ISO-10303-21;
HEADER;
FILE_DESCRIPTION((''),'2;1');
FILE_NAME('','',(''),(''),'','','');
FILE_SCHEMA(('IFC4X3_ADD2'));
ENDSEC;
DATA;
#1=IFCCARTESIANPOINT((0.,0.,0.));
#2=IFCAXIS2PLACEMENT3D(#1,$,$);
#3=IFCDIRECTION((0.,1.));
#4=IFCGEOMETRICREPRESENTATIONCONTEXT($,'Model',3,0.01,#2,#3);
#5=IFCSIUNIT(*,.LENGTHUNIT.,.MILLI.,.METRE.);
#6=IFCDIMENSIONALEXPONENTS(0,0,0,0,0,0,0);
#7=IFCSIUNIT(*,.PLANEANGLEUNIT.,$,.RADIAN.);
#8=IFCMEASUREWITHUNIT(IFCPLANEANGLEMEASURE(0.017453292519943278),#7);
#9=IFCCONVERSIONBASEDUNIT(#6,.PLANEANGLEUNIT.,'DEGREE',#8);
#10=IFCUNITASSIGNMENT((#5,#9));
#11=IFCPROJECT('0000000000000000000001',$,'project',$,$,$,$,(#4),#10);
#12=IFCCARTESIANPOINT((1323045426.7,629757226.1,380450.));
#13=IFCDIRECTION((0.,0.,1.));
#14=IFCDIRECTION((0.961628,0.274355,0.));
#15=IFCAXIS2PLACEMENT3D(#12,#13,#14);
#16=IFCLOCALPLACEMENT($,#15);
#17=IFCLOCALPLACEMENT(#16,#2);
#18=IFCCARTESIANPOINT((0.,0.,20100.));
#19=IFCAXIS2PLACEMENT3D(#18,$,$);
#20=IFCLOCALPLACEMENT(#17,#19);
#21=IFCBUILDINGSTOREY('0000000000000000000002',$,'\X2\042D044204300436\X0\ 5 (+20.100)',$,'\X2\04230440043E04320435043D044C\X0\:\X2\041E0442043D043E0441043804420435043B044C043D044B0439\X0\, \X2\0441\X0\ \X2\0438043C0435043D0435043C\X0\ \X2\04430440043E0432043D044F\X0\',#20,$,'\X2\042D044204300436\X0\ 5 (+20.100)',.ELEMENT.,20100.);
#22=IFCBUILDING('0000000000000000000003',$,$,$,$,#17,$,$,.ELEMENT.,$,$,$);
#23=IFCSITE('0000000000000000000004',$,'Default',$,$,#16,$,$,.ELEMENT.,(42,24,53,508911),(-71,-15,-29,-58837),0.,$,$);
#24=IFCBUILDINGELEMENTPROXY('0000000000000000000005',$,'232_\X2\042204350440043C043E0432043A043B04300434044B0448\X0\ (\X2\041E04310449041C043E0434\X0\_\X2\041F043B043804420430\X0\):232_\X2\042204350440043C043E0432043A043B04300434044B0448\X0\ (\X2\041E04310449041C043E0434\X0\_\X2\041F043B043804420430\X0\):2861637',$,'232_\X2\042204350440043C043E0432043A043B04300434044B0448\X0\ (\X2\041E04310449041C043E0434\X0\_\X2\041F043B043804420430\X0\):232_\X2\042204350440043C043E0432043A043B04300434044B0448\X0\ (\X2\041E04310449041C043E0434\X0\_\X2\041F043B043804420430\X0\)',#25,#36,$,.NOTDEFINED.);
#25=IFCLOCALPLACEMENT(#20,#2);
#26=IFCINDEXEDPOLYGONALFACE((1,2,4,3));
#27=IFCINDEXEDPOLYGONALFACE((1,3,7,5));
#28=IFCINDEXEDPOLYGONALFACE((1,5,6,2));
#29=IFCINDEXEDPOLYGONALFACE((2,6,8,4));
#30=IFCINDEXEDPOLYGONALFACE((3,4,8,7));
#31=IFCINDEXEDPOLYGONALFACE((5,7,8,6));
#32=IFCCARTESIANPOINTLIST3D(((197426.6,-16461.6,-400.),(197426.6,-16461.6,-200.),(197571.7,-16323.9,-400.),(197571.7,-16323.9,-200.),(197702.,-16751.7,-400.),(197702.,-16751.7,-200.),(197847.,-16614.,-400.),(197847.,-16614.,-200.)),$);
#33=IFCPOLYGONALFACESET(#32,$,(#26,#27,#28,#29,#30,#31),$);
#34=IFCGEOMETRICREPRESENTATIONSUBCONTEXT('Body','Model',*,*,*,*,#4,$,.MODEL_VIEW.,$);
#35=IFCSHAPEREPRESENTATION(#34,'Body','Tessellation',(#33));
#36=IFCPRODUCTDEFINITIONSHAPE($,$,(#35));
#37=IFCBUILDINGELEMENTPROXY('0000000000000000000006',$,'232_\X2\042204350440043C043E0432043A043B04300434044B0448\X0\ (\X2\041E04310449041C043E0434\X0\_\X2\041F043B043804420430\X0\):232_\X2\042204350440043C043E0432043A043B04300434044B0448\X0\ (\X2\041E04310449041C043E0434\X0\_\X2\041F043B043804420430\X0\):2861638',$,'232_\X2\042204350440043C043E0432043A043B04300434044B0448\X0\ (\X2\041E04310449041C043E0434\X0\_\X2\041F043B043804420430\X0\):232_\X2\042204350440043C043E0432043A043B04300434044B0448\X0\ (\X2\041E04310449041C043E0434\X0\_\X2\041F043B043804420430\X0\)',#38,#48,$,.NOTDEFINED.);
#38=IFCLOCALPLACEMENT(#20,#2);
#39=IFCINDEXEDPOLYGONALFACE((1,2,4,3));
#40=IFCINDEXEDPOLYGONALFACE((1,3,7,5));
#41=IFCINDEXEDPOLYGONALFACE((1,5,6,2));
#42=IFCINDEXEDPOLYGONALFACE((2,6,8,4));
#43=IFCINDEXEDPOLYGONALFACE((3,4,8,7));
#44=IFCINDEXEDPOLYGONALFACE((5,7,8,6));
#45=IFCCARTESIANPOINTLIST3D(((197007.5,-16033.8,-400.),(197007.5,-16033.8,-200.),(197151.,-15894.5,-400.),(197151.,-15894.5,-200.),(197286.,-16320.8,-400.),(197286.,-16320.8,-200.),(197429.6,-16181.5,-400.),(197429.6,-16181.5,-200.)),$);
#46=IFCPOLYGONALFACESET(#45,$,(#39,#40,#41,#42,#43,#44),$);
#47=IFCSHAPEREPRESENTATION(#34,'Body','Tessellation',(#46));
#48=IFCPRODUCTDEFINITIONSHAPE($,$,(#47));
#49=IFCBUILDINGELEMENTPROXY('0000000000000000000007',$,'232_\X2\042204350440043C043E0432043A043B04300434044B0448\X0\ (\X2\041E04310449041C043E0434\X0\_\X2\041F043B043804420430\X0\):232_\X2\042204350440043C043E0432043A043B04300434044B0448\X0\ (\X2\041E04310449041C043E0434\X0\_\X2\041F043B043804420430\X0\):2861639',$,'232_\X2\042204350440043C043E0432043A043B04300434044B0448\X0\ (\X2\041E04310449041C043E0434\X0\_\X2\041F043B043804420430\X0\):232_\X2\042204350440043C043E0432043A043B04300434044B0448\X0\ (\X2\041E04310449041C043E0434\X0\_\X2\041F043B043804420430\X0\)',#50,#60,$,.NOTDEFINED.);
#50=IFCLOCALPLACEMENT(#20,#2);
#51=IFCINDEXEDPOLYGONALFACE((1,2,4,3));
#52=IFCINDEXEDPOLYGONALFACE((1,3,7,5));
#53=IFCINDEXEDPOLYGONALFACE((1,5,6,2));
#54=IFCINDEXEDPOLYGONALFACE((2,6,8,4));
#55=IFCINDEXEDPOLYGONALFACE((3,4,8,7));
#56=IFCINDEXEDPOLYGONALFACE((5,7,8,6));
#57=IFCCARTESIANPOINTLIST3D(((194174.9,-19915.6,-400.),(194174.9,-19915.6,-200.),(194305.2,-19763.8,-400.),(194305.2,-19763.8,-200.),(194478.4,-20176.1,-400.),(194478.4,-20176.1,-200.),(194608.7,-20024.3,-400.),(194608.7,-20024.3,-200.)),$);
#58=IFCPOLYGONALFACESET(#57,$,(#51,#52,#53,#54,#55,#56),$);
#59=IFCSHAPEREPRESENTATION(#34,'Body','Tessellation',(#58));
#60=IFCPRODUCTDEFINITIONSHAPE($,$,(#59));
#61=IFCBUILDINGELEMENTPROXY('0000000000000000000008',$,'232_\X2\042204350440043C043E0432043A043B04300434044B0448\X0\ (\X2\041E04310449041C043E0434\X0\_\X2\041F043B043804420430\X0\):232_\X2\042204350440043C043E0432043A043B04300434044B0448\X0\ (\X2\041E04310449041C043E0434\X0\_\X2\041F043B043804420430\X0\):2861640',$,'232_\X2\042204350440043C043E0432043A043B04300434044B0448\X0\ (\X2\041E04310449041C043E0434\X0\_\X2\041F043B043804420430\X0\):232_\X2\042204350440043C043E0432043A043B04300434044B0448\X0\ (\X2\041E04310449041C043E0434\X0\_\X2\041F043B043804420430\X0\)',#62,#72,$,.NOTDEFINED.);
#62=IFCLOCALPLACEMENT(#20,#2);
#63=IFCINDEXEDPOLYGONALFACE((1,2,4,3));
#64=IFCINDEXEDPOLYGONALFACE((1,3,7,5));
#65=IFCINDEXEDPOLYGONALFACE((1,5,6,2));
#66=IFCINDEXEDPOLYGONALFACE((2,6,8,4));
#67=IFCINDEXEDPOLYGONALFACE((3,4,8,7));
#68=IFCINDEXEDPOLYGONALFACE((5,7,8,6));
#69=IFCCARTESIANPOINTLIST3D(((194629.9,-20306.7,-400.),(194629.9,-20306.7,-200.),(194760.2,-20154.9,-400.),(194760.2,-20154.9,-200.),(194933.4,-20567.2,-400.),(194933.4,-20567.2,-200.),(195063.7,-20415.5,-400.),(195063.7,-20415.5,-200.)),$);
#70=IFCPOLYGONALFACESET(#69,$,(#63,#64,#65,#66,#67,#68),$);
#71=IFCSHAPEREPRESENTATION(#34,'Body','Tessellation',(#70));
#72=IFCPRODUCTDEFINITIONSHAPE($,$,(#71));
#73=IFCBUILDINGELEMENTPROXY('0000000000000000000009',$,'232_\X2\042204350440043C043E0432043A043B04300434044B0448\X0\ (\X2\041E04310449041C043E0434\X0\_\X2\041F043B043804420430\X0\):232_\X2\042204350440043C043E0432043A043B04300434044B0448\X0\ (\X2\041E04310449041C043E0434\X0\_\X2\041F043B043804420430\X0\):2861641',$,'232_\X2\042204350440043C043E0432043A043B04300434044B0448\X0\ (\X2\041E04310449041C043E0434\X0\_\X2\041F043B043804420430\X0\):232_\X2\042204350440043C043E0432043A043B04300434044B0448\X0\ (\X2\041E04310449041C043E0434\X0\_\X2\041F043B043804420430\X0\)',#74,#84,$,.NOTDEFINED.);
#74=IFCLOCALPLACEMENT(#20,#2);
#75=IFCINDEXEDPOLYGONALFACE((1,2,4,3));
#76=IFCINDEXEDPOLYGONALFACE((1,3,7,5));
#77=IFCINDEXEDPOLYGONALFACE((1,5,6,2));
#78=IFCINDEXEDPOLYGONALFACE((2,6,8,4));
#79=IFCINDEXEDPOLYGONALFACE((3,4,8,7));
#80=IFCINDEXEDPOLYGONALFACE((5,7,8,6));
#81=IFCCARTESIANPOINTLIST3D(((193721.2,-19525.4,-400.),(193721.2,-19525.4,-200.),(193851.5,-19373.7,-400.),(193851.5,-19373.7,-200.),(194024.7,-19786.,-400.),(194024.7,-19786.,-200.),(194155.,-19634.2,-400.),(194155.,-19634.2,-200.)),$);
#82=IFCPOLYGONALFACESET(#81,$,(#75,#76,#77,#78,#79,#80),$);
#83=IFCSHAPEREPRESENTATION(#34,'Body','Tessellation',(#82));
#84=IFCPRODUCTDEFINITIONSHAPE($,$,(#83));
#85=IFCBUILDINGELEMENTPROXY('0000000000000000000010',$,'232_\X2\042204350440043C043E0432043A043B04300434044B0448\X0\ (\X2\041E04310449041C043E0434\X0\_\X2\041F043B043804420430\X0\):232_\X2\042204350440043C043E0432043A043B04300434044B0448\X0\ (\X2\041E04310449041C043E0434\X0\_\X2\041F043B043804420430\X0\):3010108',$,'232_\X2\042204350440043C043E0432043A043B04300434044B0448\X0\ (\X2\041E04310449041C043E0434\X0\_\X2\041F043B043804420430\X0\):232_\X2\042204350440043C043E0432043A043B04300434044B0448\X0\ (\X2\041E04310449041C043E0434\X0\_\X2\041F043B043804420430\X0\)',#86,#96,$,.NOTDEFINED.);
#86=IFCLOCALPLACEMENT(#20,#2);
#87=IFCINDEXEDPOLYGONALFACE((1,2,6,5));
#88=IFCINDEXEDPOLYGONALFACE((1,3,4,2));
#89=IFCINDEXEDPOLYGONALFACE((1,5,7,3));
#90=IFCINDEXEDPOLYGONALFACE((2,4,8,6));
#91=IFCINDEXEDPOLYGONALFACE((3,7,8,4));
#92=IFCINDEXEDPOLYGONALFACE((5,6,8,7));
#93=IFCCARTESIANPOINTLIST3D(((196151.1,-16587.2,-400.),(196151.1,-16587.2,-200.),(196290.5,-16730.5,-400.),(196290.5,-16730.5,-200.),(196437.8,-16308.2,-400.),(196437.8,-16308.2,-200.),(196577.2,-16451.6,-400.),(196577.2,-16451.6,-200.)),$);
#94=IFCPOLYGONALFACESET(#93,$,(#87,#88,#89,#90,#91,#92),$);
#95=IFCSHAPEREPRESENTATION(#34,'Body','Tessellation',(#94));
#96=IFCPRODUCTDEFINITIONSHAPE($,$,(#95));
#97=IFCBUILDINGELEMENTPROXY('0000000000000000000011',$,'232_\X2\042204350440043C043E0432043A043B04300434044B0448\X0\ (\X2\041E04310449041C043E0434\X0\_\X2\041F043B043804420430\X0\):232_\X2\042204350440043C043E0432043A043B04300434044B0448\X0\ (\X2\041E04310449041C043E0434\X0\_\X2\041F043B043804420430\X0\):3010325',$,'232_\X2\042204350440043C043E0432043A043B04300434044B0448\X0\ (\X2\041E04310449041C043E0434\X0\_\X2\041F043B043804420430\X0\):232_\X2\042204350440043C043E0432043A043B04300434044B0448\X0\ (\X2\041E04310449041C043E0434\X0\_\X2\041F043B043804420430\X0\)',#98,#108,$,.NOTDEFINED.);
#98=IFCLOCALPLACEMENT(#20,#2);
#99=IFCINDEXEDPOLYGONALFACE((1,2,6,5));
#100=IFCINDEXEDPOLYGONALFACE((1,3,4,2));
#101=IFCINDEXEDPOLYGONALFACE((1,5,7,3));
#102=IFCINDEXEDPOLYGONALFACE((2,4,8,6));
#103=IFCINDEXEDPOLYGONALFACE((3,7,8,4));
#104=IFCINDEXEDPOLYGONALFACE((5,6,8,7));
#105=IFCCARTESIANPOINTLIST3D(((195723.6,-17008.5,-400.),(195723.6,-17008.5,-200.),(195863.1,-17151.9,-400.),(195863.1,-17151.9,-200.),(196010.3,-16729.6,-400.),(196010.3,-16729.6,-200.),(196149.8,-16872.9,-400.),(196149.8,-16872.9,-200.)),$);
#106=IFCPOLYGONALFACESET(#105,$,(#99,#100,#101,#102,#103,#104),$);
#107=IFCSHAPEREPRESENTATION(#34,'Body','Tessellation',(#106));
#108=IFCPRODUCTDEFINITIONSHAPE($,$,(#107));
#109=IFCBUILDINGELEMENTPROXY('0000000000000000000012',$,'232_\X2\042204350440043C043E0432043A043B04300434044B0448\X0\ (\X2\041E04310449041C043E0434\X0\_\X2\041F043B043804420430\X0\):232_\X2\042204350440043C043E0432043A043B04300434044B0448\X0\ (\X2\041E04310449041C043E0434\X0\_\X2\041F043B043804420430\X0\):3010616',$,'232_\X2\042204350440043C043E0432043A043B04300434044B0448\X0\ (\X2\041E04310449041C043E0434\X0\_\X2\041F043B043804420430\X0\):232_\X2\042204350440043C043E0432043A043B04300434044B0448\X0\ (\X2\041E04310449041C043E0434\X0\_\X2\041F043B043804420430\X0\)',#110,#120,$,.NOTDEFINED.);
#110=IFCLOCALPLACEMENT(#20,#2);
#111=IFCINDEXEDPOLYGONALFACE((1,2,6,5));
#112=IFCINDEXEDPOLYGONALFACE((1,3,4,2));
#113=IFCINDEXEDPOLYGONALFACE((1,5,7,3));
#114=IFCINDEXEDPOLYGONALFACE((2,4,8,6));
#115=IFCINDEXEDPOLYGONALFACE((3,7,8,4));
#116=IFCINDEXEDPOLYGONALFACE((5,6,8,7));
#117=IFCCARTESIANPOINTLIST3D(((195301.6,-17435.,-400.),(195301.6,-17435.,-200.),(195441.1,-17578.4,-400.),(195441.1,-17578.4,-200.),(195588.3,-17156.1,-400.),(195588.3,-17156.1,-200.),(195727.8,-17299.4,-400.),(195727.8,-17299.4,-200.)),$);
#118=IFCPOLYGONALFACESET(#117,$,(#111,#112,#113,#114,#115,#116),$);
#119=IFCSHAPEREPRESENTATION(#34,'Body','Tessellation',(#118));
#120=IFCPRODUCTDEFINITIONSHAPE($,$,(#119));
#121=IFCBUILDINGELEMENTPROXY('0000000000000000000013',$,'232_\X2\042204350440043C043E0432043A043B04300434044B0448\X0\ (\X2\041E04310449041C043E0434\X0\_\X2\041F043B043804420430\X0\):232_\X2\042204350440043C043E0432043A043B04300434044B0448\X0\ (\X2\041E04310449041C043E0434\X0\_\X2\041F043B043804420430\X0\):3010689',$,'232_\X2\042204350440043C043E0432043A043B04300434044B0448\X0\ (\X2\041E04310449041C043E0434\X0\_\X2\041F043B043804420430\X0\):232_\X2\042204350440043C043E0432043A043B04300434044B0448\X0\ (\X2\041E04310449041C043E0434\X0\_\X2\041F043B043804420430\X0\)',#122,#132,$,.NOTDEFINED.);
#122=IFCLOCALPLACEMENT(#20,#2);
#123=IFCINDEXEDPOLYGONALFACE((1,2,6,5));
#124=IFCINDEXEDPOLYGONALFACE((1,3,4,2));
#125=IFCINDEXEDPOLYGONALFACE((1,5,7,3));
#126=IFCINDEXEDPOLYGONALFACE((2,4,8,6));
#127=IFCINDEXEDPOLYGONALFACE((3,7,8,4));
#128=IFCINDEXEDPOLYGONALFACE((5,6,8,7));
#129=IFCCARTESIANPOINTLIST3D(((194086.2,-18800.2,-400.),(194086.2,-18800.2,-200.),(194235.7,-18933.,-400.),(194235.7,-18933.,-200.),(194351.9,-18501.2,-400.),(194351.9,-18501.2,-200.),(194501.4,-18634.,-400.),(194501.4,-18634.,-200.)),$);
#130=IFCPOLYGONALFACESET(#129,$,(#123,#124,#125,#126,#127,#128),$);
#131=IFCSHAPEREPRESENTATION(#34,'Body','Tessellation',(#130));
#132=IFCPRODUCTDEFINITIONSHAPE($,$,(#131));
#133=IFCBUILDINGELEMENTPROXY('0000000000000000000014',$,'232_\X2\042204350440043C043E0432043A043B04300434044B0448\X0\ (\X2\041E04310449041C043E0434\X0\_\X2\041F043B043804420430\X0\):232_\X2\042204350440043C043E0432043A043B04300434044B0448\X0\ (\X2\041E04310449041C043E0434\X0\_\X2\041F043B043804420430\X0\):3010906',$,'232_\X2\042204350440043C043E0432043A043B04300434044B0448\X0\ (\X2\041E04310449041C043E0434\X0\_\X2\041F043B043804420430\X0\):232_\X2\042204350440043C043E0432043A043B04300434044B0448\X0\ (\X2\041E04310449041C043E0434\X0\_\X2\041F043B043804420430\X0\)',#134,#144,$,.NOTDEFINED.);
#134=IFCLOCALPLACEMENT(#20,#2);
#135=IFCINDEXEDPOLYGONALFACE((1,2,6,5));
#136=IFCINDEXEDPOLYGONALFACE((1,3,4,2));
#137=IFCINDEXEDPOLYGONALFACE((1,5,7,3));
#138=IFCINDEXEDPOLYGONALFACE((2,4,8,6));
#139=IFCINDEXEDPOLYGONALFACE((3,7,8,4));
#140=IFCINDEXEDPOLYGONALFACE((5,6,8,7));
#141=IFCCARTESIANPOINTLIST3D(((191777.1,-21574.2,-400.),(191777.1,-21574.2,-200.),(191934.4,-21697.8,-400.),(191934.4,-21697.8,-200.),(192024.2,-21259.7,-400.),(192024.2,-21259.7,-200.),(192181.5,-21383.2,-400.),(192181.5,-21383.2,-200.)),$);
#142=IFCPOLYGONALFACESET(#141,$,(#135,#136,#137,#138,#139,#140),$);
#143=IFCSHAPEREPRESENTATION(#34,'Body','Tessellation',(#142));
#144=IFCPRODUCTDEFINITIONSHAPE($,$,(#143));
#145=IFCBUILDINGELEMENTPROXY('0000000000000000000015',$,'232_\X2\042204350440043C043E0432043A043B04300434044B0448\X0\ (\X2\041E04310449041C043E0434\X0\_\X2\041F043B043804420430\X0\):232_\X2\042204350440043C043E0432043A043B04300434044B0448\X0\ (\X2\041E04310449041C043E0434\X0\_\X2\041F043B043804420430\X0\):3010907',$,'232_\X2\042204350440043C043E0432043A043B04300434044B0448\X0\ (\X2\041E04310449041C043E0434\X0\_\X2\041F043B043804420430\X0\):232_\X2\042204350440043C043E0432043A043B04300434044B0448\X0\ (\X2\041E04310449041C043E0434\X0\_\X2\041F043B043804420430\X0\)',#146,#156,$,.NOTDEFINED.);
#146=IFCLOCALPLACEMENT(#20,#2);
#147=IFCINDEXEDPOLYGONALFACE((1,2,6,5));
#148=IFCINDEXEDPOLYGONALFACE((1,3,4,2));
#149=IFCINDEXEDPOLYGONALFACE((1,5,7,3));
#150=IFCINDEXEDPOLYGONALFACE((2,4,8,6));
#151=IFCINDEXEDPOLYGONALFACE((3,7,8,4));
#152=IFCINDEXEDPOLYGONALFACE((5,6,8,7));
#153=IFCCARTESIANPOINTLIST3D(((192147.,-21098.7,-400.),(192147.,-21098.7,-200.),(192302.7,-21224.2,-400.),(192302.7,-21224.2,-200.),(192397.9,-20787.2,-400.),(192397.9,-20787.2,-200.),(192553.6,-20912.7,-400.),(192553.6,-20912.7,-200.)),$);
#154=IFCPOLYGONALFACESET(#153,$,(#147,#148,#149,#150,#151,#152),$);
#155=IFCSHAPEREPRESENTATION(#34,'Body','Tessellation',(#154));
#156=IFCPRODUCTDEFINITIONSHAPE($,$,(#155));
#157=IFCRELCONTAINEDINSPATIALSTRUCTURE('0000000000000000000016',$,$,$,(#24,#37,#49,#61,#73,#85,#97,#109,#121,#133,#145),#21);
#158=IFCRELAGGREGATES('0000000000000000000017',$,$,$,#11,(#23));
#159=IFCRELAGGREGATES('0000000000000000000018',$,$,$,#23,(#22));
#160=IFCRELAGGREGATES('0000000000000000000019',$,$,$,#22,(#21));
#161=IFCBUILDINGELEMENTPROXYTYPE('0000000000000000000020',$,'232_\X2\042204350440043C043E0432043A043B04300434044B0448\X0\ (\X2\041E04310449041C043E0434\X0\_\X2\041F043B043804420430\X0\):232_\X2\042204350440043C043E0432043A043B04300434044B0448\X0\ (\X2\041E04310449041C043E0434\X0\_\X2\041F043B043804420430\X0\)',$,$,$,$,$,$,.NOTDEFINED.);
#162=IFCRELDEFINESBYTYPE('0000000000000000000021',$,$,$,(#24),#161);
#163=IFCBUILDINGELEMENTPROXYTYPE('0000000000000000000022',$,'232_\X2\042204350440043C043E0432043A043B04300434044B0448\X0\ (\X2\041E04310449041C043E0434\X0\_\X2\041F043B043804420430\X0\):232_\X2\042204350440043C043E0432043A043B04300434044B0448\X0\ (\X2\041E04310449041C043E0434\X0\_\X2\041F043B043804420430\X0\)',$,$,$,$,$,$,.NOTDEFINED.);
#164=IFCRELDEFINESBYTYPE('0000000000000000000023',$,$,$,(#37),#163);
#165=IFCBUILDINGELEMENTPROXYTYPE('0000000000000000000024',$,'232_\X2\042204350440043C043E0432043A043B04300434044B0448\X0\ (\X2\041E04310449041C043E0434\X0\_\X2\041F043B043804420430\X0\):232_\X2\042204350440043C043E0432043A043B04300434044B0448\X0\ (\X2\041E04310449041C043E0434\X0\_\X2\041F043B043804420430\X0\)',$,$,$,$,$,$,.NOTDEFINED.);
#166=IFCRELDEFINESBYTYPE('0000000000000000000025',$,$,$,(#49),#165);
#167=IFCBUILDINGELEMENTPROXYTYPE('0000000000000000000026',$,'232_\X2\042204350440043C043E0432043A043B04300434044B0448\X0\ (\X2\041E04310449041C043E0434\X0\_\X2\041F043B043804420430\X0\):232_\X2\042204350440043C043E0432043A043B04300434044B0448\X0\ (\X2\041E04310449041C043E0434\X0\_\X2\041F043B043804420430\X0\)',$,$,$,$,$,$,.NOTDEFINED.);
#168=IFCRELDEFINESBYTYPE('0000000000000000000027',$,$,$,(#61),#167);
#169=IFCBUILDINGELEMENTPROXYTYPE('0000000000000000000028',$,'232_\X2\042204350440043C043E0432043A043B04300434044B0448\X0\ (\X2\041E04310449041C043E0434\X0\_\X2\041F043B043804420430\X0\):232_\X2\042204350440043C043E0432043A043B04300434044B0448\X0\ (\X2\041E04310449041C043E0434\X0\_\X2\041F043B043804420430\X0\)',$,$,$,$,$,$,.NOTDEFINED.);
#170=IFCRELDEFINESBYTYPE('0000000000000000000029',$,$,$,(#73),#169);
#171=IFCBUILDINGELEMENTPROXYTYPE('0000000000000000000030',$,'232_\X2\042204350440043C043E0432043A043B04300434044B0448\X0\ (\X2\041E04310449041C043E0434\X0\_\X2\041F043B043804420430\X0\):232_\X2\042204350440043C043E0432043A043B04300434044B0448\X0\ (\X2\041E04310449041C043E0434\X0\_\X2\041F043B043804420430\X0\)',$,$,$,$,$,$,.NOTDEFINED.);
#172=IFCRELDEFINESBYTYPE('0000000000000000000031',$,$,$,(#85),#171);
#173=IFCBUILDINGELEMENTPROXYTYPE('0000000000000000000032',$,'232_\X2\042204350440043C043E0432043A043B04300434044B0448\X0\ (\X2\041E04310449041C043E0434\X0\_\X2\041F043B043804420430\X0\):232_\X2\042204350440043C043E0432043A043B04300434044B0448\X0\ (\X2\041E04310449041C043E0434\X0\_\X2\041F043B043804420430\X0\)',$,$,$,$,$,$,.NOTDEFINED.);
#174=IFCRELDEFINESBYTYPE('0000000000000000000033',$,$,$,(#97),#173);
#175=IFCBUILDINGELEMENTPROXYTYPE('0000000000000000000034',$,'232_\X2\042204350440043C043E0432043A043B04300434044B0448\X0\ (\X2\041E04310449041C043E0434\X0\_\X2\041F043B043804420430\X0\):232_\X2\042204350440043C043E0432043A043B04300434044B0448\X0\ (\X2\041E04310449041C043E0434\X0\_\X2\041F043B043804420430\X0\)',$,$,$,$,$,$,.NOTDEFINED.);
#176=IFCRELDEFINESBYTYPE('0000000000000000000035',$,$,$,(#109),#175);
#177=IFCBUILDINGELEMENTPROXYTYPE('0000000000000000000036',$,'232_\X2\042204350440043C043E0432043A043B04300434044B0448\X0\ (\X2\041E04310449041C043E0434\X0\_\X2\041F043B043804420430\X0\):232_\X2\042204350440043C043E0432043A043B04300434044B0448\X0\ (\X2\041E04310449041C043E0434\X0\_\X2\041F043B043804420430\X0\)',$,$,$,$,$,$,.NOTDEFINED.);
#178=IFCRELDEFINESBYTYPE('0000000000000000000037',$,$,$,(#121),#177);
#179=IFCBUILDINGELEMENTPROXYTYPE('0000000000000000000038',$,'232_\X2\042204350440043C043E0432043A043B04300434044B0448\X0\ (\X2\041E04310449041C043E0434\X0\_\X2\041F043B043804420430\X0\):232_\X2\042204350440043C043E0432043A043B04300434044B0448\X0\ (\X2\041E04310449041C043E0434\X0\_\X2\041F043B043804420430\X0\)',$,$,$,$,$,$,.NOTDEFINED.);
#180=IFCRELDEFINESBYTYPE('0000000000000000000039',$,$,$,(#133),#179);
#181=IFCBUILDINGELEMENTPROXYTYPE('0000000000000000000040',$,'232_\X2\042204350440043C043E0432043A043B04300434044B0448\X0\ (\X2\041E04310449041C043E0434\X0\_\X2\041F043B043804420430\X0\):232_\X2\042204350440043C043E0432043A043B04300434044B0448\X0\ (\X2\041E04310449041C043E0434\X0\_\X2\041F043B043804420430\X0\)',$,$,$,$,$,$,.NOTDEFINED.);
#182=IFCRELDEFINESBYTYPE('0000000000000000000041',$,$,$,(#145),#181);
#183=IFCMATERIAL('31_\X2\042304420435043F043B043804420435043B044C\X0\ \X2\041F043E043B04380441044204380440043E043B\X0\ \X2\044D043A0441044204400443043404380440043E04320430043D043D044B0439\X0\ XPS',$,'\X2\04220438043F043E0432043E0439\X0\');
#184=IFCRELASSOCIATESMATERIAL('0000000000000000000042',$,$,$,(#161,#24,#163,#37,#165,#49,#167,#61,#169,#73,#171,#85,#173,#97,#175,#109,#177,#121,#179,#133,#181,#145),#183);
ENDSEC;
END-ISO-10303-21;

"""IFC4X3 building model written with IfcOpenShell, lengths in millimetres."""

from ifc_helpers import new_model, entity, si_unit, converted_unit, direction, frame, frame_2d, origin, origin_2d_with_axis, place, context, subcontext, project, spatial, rectangle, extrude, source, transform, mapped, material, type_object, type_shapes, element, save


model = new_model("IFC4X3")

# Units and contexts
model_context = context("Model", 3, precision=0.01, world=origin(), true_north=direction((0.0, 1.0)))
body_context = subcontext(model_context, "Body", "Model", "MODEL_VIEW")
ifc_project = project(units=[si_unit("LENGTHUNIT", "METRE", prefix="MILLI"), converted_unit("PLANEANGLEUNIT", "DEGREE", entity("IfcPlaneAngleMeasure", 0.017453292519943278), si_unit("PLANEANGLEUNIT", "RADIAN"), dimensions=[0, 0, 0, 0, 0, 0, 0])], contexts=[model_context])

# Site, building, storey
site_placement = place(None, frame((1323045426.7, 629757226.1, 380450.0), z_axis=(0.0, 0.0, 1.0), x_axis=(0.961628, 0.274355, 0.0)))
site = spatial("IfcSite", under=ifc_project, at=site_placement, Name="Default", CompositionType="ELEMENT", RefLatitude=(42, 24, 53, 508911), RefLongitude=(-71, -15, -29, -58837), RefElevation=0.0)
building_placement = place(site_placement, origin())
building = spatial("IfcBuilding", under=site, at=building_placement, CompositionType="ELEMENT")
storey_placement = place(building_placement, frame((0.0, 0.0, 20100.0)))
storey = spatial("IfcBuildingStorey", under=building, at=storey_placement, Name="Этаж 5 (+20.100)", ObjectType="Уровень:Относительный, с именем уровня", LongName="Этаж 5 (+20.100)", CompositionType="ELEMENT", Elevation=20100.0)

# Building element proxies
ifc_material_1 = material(Name="31_Утеплитель Полистирол экструдированный XPS", Category="Типовой")
building_element_proxy_type_1 = type_object("IfcBuildingElementProxyType", Name="232_Термовкладыш (ОбщМод_Плита):232_Термовкладыш (ОбщМод_Плита)", PredefinedType="NOTDEFINED", material=ifc_material_1)
shared_shape_1 = source(origin(), body_context, "Body", "SweptSolid", [
    extrude(rectangle(XDim=400.0, YDim=200.0, at=frame_2d((0.0, 0.0), x_axis=(1.0, 0.0))), frame((197636.8, -16537.8, -200.0), z_axis=(0.0, 0.0, 1.0), x_axis=(-0.688483, 0.725252, 0.0)), (0.0, 0.0, 1.0), 200.0),
])
type_shapes(building_element_proxy_type_1, [shared_shape_1])
proxy_1_placement = place(storey_placement, frame((0.0, 0.0, -200.0)))
element("IfcBuildingElementProxy", 1, at=proxy_1_placement, inside=storey, type_object=building_element_proxy_type_1, material=ifc_material_1, Name="232_Термовкладыш (ОбщМод_Плита):232_Термовкладыш (ОбщМод_Плита):2861637", ObjectType="232_Термовкладыш (ОбщМод_Плита):232_Термовкладыш (ОбщМод_Плита)", PredefinedType="NOTDEFINED", context=body_context, shape_type="MappedRepresentation", body=[
    mapped(shared_shape_1, transform((0.0, 0.0, 0.0), scale=1.0)),
])
building_element_proxy_type_2 = type_object("IfcBuildingElementProxyType", Name="232_Термовкладыш (ОбщМод_Плита):232_Термовкладыш (ОбщМод_Плита)", PredefinedType="NOTDEFINED", material=ifc_material_1)
shared_shape_2 = source(origin(), body_context, "Body", "SweptSolid", [
    extrude(rectangle(XDim=400.0, YDim=200.0, at=frame_2d((0.0, 0.0), x_axis=(1.0, 0.0))), frame((197218.5, -16107.6, -200.0), z_axis=(0.0, 0.0, 1.0), x_axis=(-0.696452, 0.717604, 0.0)), (0.0, 0.0, 1.0), 200.0),
])
type_shapes(building_element_proxy_type_2, [shared_shape_2])
proxy_2_placement = place(storey_placement, frame((0.0, 0.0, -200.0)))
element("IfcBuildingElementProxy", 2, at=proxy_2_placement, inside=storey, type_object=building_element_proxy_type_2, material=ifc_material_1, Name="232_Термовкладыш (ОбщМод_Плита):232_Термовкладыш (ОбщМод_Плита):2861638", ObjectType="232_Термовкладыш (ОбщМод_Плита):232_Термовкладыш (ОбщМод_Плита)", PredefinedType="NOTDEFINED", context=body_context, shape_type="MappedRepresentation", body=[
    mapped(shared_shape_2, transform((0.0, 0.0, 0.0), scale=1.0)),
])
building_element_proxy_type_3 = type_object("IfcBuildingElementProxyType", Name="232_Термовкладыш (ОбщМод_Плита):232_Термовкладыш (ОбщМод_Плита)", PredefinedType="NOTDEFINED", material=ifc_material_1)
shared_shape_3 = source(origin(), body_context, "Body", "SweptSolid", [
    extrude(rectangle(XDim=400.0, YDim=200.0, at=frame_2d((0.0, 0.0), x_axis=(1.0, 0.0))), frame((194391.8, -19969.9, -200.0), z_axis=(0.0, 0.0, 1.0), x_axis=(-0.758819, 0.651302, 0.0)), (0.0, 0.0, 1.0), 200.0),
])
type_shapes(building_element_proxy_type_3, [shared_shape_3])
proxy_3_placement = place(storey_placement, frame((0.0, 0.0, -200.0)))
element("IfcBuildingElementProxy", 3, at=proxy_3_placement, inside=storey, type_object=building_element_proxy_type_3, material=ifc_material_1, Name="232_Термовкладыш (ОбщМод_Плита):232_Термовкладыш (ОбщМод_Плита):2861639", ObjectType="232_Термовкладыш (ОбщМод_Плита):232_Термовкладыш (ОбщМод_Плита)", PredefinedType="NOTDEFINED", context=body_context, shape_type="MappedRepresentation", body=[
    mapped(shared_shape_3, transform((0.0, 0.0, 0.0), scale=1.0)),
])
building_element_proxy_type_4 = type_object("IfcBuildingElementProxyType", Name="232_Термовкладыш (ОбщМод_Плита):232_Термовкладыш (ОбщМод_Плита)", PredefinedType="NOTDEFINED", material=ifc_material_1)
shared_shape_4 = source(origin(), body_context, "Body", "SweptSolid", [
    extrude(rectangle(XDim=400.0, YDim=200.0, at=frame_2d((0.0, 0.0), x_axis=(1.0, 0.0))), frame((194846.8, -20361.1, -200.0), z_axis=(0.0, 0.0, 1.0), x_axis=(-0.758819, 0.651302, 0.0)), (0.0, 0.0, 1.0), 200.0),
])
type_shapes(building_element_proxy_type_4, [shared_shape_4])
proxy_4_placement = place(storey_placement, frame((0.0, 0.0, -200.0)))
element("IfcBuildingElementProxy", 4, at=proxy_4_placement, inside=storey, type_object=building_element_proxy_type_4, material=ifc_material_1, Name="232_Термовкладыш (ОбщМод_Плита):232_Термовкладыш (ОбщМод_Плита):2861640", ObjectType="232_Термовкладыш (ОбщМод_Плита):232_Термовкладыш (ОбщМод_Плита)", PredefinedType="NOTDEFINED", context=body_context, shape_type="MappedRepresentation", body=[
    mapped(shared_shape_4, transform((0.0, 0.0, 0.0), scale=1.0)),
])
building_element_proxy_type_5 = type_object("IfcBuildingElementProxyType", Name="232_Термовкладыш (ОбщМод_Плита):232_Термовкладыш (ОбщМод_Плита)", PredefinedType="NOTDEFINED", material=ifc_material_1)
shared_shape_5 = source(origin(), body_context, "Body", "SweptSolid", [
    extrude(rectangle(XDim=400.0, YDim=200.0, at=frame_2d((0.0, 0.0), x_axis=(1.0, 0.0))), frame((193938.1, -19579.8, -200.0), z_axis=(0.0, 0.0, 1.0), x_axis=(-0.758819, 0.651302, 0.0)), (0.0, 0.0, 1.0), 200.0),
])
type_shapes(building_element_proxy_type_5, [shared_shape_5])
proxy_5_placement = place(storey_placement, frame((0.0, 0.0, -200.0)))
element("IfcBuildingElementProxy", 5, at=proxy_5_placement, inside=storey, type_object=building_element_proxy_type_5, material=ifc_material_1, Name="232_Термовкладыш (ОбщМод_Плита):232_Термовкладыш (ОбщМод_Плита):2861641", ObjectType="232_Термовкладыш (ОбщМод_Плита):232_Термовкладыш (ОбщМод_Плита)", PredefinedType="NOTDEFINED", context=body_context, shape_type="MappedRepresentation", body=[
    mapped(shared_shape_5, transform((0.0, 0.0, 0.0), scale=1.0)),
])
building_element_proxy_type_6 = type_object("IfcBuildingElementProxyType", Name="232_Термовкладыш (ОбщМод_Плита):232_Термовкладыш (ОбщМод_Плита)", PredefinedType="NOTDEFINED", material=ifc_material_1)
shared_shape_6 = source(origin(), body_context, "Body", "SweptSolid", [
    extrude(rectangle(XDim=400.0, YDim=200.0, at=frame_2d((0.0, 0.0), x_axis=(1.0, 0.0))), frame((196364.1, -16519.4, -200.0), z_axis=(0.0, 0.0, 1.0), x_axis=(0.716712, 0.697369, 0.0)), (0.0, 0.0, 1.0), 200.0),
])
type_shapes(building_element_proxy_type_6, [shared_shape_6])
proxy_6_placement = place(storey_placement, frame((0.0, 0.0, -200.0)))
element("IfcBuildingElementProxy", 6, at=proxy_6_placement, inside=storey, type_object=building_element_proxy_type_6, material=ifc_material_1, Name="232_Термовкладыш (ОбщМод_Плита):232_Термовкладыш (ОбщМод_Плита):3010108", ObjectType="232_Термовкладыш (ОбщМод_Плита):232_Термовкладыш (ОбщМод_Плита)", PredefinedType="NOTDEFINED", context=body_context, shape_type="MappedRepresentation", body=[
    mapped(shared_shape_6, transform((0.0, 0.0, 0.0), scale=1.0)),
])
building_element_proxy_type_7 = type_object("IfcBuildingElementProxyType", Name="232_Термовкладыш (ОбщМод_Плита):232_Термовкладыш (ОбщМод_Плита)", PredefinedType="NOTDEFINED", material=ifc_material_1)
shared_shape_7 = source(origin(), body_context, "Body", "SweptSolid", [
    extrude(rectangle(XDim=400.0, YDim=200.0, at=frame_2d((0.0, 0.0), x_axis=(1.0, 0.0))), frame((195936.7, -16940.7, -200.0), z_axis=(0.0, 0.0, 1.0), x_axis=(0.716712, 0.697369, 0.0)), (0.0, 0.0, 1.0), 200.0),
])
type_shapes(building_element_proxy_type_7, [shared_shape_7])
proxy_7_placement = place(storey_placement, frame((0.0, 0.0, -200.0)))
element("IfcBuildingElementProxy", 7, at=proxy_7_placement, inside=storey, type_object=building_element_proxy_type_7, material=ifc_material_1, Name="232_Термовкладыш (ОбщМод_Плита):232_Термовкладыш (ОбщМод_Плита):3010325", ObjectType="232_Термовкладыш (ОбщМод_Плита):232_Термовкладыш (ОбщМод_Плита)", PredefinedType="NOTDEFINED", context=body_context, shape_type="MappedRepresentation", body=[
    mapped(shared_shape_7, transform((0.0, 0.0, 0.0), scale=1.0)),
])
building_element_proxy_type_8 = type_object("IfcBuildingElementProxyType", Name="232_Термовкладыш (ОбщМод_Плита):232_Термовкладыш (ОбщМод_Плита)", PredefinedType="NOTDEFINED", material=ifc_material_1)
shared_shape_8 = source(origin(), body_context, "Body", "SweptSolid", [
    extrude(rectangle(XDim=400.0, YDim=200.0, at=frame_2d((0.0, 0.0), x_axis=(1.0, 0.0))), frame((195514.7, -17367.2, -200.0), z_axis=(0.0, 0.0, 1.0), x_axis=(0.716712, 0.697369, 0.0)), (0.0, 0.0, 1.0), 200.0),
])
type_shapes(building_element_proxy_type_8, [shared_shape_8])
proxy_8_placement = place(storey_placement, frame((0.0, 0.0, -200.0)))
element("IfcBuildingElementProxy", 8, at=proxy_8_placement, inside=storey, type_object=building_element_proxy_type_8, material=ifc_material_1, Name="232_Термовкладыш (ОбщМод_Плита):232_Термовкладыш (ОбщМод_Плита):3010616", ObjectType="232_Термовкладыш (ОбщМод_Плита):232_Термовкладыш (ОбщМод_Плита)", PredefinedType="NOTDEFINED", context=body_context, shape_type="MappedRepresentation", body=[
    mapped(shared_shape_8, transform((0.0, 0.0, 0.0), scale=1.0)),
])
building_element_proxy_type_9 = type_object("IfcBuildingElementProxyType", Name="232_Термовкладыш (ОбщМод_Плита):232_Термовкладыш (ОбщМод_Плита)", PredefinedType="NOTDEFINED", material=ifc_material_1)
shared_shape_9 = source(origin(), body_context, "Body", "SweptSolid", [
    extrude(rectangle(XDim=400.0, YDim=200.0, at=frame_2d((0.0, 0.0), x_axis=(1.0, 0.0))), frame((194293.8, -18717.1, -200.0), z_axis=(0.0, 0.0, 1.0), x_axis=(0.66421, 0.747546, 0.0)), (0.0, 0.0, 1.0), 200.0),
])
type_shapes(building_element_proxy_type_9, [shared_shape_9])
proxy_9_placement = place(storey_placement, frame((0.0, 0.0, -200.0)))
element("IfcBuildingElementProxy", 9, at=proxy_9_placement, inside=storey, type_object=building_element_proxy_type_9, material=ifc_material_1, Name="232_Термовкладыш (ОбщМод_Плита):232_Термовкладыш (ОбщМод_Плита):3010689", ObjectType="232_Термовкладыш (ОбщМод_Плита):232_Термовкладыш (ОбщМод_Плита)", PredefinedType="NOTDEFINED", context=body_context, shape_type="MappedRepresentation", body=[
    mapped(shared_shape_9, transform((0.0, 0.0, 0.0), scale=1.0)),
])
building_element_proxy_type_10 = type_object("IfcBuildingElementProxyType", Name="232_Термовкладыш (ОбщМод_Плита):232_Термовкладыш (ОбщМод_Плита)", PredefinedType="NOTDEFINED", material=ifc_material_1)
shared_shape_10 = source(origin(), body_context, "Body", "SweptSolid", [
    extrude(rectangle(XDim=400.0, YDim=200.0, at=origin_2d_with_axis()), frame((191979.3, -21478.7, -200.0), z_axis=(0.0, 0.0, 1.0), x_axis=(0.61777, 0.786358, 0.0)), (0.0, 0.0, 1.0), 200.0),
])
type_shapes(building_element_proxy_type_10, [shared_shape_10])
proxy_10_placement = place(storey_placement, frame((0.0, 0.0, -200.0)))
element("IfcBuildingElementProxy", 10, at=proxy_10_placement, inside=storey, type_object=building_element_proxy_type_10, material=ifc_material_1, Name="232_Термовкладыш (ОбщМод_Плита):232_Термовкладыш (ОбщМод_Плита):3010906", ObjectType="232_Термовкладыш (ОбщМод_Плита):232_Термовкладыш (ОбщМод_Плита)", PredefinedType="NOTDEFINED", context=body_context, shape_type="MappedRepresentation", body=[
    mapped(shared_shape_10, transform((0.0, 0.0, 0.0), scale=1.0)),
])
building_element_proxy_type_11 = type_object("IfcBuildingElementProxyType", Name="232_Термовкладыш (ОбщМод_Плита):232_Термовкладыш (ОбщМод_Плита)", PredefinedType="NOTDEFINED", material=ifc_material_1)
shared_shape_11 = source(origin(), body_context, "Body", "SweptSolid", [
    extrude(rectangle(XDim=400.0, YDim=200.0, at=origin_2d_with_axis()), frame((192350.3, -21005.7, -200.0), z_axis=(0.0, 0.0, 1.0), x_axis=(0.627245, 0.778822, 0.0)), (0.0, 0.0, 1.0), 200.0),
])
type_shapes(building_element_proxy_type_11, [shared_shape_11])
proxy_11_placement = place(storey_placement, frame((0.0, 0.0, -200.0)))
element("IfcBuildingElementProxy", 11, at=proxy_11_placement, inside=storey, type_object=building_element_proxy_type_11, material=ifc_material_1, Name="232_Термовкладыш (ОбщМод_Плита):232_Термовкладыш (ОбщМод_Плита):3010907", ObjectType="232_Термовкладыш (ОбщМод_Плита):232_Термовкладыш (ОбщМод_Плита)", PredefinedType="NOTDEFINED", context=body_context, shape_type="MappedRepresentation", body=[
    mapped(shared_shape_11, transform((0.0, 0.0, 0.0), scale=1.0)),
])

save(model, "model.ifc")
